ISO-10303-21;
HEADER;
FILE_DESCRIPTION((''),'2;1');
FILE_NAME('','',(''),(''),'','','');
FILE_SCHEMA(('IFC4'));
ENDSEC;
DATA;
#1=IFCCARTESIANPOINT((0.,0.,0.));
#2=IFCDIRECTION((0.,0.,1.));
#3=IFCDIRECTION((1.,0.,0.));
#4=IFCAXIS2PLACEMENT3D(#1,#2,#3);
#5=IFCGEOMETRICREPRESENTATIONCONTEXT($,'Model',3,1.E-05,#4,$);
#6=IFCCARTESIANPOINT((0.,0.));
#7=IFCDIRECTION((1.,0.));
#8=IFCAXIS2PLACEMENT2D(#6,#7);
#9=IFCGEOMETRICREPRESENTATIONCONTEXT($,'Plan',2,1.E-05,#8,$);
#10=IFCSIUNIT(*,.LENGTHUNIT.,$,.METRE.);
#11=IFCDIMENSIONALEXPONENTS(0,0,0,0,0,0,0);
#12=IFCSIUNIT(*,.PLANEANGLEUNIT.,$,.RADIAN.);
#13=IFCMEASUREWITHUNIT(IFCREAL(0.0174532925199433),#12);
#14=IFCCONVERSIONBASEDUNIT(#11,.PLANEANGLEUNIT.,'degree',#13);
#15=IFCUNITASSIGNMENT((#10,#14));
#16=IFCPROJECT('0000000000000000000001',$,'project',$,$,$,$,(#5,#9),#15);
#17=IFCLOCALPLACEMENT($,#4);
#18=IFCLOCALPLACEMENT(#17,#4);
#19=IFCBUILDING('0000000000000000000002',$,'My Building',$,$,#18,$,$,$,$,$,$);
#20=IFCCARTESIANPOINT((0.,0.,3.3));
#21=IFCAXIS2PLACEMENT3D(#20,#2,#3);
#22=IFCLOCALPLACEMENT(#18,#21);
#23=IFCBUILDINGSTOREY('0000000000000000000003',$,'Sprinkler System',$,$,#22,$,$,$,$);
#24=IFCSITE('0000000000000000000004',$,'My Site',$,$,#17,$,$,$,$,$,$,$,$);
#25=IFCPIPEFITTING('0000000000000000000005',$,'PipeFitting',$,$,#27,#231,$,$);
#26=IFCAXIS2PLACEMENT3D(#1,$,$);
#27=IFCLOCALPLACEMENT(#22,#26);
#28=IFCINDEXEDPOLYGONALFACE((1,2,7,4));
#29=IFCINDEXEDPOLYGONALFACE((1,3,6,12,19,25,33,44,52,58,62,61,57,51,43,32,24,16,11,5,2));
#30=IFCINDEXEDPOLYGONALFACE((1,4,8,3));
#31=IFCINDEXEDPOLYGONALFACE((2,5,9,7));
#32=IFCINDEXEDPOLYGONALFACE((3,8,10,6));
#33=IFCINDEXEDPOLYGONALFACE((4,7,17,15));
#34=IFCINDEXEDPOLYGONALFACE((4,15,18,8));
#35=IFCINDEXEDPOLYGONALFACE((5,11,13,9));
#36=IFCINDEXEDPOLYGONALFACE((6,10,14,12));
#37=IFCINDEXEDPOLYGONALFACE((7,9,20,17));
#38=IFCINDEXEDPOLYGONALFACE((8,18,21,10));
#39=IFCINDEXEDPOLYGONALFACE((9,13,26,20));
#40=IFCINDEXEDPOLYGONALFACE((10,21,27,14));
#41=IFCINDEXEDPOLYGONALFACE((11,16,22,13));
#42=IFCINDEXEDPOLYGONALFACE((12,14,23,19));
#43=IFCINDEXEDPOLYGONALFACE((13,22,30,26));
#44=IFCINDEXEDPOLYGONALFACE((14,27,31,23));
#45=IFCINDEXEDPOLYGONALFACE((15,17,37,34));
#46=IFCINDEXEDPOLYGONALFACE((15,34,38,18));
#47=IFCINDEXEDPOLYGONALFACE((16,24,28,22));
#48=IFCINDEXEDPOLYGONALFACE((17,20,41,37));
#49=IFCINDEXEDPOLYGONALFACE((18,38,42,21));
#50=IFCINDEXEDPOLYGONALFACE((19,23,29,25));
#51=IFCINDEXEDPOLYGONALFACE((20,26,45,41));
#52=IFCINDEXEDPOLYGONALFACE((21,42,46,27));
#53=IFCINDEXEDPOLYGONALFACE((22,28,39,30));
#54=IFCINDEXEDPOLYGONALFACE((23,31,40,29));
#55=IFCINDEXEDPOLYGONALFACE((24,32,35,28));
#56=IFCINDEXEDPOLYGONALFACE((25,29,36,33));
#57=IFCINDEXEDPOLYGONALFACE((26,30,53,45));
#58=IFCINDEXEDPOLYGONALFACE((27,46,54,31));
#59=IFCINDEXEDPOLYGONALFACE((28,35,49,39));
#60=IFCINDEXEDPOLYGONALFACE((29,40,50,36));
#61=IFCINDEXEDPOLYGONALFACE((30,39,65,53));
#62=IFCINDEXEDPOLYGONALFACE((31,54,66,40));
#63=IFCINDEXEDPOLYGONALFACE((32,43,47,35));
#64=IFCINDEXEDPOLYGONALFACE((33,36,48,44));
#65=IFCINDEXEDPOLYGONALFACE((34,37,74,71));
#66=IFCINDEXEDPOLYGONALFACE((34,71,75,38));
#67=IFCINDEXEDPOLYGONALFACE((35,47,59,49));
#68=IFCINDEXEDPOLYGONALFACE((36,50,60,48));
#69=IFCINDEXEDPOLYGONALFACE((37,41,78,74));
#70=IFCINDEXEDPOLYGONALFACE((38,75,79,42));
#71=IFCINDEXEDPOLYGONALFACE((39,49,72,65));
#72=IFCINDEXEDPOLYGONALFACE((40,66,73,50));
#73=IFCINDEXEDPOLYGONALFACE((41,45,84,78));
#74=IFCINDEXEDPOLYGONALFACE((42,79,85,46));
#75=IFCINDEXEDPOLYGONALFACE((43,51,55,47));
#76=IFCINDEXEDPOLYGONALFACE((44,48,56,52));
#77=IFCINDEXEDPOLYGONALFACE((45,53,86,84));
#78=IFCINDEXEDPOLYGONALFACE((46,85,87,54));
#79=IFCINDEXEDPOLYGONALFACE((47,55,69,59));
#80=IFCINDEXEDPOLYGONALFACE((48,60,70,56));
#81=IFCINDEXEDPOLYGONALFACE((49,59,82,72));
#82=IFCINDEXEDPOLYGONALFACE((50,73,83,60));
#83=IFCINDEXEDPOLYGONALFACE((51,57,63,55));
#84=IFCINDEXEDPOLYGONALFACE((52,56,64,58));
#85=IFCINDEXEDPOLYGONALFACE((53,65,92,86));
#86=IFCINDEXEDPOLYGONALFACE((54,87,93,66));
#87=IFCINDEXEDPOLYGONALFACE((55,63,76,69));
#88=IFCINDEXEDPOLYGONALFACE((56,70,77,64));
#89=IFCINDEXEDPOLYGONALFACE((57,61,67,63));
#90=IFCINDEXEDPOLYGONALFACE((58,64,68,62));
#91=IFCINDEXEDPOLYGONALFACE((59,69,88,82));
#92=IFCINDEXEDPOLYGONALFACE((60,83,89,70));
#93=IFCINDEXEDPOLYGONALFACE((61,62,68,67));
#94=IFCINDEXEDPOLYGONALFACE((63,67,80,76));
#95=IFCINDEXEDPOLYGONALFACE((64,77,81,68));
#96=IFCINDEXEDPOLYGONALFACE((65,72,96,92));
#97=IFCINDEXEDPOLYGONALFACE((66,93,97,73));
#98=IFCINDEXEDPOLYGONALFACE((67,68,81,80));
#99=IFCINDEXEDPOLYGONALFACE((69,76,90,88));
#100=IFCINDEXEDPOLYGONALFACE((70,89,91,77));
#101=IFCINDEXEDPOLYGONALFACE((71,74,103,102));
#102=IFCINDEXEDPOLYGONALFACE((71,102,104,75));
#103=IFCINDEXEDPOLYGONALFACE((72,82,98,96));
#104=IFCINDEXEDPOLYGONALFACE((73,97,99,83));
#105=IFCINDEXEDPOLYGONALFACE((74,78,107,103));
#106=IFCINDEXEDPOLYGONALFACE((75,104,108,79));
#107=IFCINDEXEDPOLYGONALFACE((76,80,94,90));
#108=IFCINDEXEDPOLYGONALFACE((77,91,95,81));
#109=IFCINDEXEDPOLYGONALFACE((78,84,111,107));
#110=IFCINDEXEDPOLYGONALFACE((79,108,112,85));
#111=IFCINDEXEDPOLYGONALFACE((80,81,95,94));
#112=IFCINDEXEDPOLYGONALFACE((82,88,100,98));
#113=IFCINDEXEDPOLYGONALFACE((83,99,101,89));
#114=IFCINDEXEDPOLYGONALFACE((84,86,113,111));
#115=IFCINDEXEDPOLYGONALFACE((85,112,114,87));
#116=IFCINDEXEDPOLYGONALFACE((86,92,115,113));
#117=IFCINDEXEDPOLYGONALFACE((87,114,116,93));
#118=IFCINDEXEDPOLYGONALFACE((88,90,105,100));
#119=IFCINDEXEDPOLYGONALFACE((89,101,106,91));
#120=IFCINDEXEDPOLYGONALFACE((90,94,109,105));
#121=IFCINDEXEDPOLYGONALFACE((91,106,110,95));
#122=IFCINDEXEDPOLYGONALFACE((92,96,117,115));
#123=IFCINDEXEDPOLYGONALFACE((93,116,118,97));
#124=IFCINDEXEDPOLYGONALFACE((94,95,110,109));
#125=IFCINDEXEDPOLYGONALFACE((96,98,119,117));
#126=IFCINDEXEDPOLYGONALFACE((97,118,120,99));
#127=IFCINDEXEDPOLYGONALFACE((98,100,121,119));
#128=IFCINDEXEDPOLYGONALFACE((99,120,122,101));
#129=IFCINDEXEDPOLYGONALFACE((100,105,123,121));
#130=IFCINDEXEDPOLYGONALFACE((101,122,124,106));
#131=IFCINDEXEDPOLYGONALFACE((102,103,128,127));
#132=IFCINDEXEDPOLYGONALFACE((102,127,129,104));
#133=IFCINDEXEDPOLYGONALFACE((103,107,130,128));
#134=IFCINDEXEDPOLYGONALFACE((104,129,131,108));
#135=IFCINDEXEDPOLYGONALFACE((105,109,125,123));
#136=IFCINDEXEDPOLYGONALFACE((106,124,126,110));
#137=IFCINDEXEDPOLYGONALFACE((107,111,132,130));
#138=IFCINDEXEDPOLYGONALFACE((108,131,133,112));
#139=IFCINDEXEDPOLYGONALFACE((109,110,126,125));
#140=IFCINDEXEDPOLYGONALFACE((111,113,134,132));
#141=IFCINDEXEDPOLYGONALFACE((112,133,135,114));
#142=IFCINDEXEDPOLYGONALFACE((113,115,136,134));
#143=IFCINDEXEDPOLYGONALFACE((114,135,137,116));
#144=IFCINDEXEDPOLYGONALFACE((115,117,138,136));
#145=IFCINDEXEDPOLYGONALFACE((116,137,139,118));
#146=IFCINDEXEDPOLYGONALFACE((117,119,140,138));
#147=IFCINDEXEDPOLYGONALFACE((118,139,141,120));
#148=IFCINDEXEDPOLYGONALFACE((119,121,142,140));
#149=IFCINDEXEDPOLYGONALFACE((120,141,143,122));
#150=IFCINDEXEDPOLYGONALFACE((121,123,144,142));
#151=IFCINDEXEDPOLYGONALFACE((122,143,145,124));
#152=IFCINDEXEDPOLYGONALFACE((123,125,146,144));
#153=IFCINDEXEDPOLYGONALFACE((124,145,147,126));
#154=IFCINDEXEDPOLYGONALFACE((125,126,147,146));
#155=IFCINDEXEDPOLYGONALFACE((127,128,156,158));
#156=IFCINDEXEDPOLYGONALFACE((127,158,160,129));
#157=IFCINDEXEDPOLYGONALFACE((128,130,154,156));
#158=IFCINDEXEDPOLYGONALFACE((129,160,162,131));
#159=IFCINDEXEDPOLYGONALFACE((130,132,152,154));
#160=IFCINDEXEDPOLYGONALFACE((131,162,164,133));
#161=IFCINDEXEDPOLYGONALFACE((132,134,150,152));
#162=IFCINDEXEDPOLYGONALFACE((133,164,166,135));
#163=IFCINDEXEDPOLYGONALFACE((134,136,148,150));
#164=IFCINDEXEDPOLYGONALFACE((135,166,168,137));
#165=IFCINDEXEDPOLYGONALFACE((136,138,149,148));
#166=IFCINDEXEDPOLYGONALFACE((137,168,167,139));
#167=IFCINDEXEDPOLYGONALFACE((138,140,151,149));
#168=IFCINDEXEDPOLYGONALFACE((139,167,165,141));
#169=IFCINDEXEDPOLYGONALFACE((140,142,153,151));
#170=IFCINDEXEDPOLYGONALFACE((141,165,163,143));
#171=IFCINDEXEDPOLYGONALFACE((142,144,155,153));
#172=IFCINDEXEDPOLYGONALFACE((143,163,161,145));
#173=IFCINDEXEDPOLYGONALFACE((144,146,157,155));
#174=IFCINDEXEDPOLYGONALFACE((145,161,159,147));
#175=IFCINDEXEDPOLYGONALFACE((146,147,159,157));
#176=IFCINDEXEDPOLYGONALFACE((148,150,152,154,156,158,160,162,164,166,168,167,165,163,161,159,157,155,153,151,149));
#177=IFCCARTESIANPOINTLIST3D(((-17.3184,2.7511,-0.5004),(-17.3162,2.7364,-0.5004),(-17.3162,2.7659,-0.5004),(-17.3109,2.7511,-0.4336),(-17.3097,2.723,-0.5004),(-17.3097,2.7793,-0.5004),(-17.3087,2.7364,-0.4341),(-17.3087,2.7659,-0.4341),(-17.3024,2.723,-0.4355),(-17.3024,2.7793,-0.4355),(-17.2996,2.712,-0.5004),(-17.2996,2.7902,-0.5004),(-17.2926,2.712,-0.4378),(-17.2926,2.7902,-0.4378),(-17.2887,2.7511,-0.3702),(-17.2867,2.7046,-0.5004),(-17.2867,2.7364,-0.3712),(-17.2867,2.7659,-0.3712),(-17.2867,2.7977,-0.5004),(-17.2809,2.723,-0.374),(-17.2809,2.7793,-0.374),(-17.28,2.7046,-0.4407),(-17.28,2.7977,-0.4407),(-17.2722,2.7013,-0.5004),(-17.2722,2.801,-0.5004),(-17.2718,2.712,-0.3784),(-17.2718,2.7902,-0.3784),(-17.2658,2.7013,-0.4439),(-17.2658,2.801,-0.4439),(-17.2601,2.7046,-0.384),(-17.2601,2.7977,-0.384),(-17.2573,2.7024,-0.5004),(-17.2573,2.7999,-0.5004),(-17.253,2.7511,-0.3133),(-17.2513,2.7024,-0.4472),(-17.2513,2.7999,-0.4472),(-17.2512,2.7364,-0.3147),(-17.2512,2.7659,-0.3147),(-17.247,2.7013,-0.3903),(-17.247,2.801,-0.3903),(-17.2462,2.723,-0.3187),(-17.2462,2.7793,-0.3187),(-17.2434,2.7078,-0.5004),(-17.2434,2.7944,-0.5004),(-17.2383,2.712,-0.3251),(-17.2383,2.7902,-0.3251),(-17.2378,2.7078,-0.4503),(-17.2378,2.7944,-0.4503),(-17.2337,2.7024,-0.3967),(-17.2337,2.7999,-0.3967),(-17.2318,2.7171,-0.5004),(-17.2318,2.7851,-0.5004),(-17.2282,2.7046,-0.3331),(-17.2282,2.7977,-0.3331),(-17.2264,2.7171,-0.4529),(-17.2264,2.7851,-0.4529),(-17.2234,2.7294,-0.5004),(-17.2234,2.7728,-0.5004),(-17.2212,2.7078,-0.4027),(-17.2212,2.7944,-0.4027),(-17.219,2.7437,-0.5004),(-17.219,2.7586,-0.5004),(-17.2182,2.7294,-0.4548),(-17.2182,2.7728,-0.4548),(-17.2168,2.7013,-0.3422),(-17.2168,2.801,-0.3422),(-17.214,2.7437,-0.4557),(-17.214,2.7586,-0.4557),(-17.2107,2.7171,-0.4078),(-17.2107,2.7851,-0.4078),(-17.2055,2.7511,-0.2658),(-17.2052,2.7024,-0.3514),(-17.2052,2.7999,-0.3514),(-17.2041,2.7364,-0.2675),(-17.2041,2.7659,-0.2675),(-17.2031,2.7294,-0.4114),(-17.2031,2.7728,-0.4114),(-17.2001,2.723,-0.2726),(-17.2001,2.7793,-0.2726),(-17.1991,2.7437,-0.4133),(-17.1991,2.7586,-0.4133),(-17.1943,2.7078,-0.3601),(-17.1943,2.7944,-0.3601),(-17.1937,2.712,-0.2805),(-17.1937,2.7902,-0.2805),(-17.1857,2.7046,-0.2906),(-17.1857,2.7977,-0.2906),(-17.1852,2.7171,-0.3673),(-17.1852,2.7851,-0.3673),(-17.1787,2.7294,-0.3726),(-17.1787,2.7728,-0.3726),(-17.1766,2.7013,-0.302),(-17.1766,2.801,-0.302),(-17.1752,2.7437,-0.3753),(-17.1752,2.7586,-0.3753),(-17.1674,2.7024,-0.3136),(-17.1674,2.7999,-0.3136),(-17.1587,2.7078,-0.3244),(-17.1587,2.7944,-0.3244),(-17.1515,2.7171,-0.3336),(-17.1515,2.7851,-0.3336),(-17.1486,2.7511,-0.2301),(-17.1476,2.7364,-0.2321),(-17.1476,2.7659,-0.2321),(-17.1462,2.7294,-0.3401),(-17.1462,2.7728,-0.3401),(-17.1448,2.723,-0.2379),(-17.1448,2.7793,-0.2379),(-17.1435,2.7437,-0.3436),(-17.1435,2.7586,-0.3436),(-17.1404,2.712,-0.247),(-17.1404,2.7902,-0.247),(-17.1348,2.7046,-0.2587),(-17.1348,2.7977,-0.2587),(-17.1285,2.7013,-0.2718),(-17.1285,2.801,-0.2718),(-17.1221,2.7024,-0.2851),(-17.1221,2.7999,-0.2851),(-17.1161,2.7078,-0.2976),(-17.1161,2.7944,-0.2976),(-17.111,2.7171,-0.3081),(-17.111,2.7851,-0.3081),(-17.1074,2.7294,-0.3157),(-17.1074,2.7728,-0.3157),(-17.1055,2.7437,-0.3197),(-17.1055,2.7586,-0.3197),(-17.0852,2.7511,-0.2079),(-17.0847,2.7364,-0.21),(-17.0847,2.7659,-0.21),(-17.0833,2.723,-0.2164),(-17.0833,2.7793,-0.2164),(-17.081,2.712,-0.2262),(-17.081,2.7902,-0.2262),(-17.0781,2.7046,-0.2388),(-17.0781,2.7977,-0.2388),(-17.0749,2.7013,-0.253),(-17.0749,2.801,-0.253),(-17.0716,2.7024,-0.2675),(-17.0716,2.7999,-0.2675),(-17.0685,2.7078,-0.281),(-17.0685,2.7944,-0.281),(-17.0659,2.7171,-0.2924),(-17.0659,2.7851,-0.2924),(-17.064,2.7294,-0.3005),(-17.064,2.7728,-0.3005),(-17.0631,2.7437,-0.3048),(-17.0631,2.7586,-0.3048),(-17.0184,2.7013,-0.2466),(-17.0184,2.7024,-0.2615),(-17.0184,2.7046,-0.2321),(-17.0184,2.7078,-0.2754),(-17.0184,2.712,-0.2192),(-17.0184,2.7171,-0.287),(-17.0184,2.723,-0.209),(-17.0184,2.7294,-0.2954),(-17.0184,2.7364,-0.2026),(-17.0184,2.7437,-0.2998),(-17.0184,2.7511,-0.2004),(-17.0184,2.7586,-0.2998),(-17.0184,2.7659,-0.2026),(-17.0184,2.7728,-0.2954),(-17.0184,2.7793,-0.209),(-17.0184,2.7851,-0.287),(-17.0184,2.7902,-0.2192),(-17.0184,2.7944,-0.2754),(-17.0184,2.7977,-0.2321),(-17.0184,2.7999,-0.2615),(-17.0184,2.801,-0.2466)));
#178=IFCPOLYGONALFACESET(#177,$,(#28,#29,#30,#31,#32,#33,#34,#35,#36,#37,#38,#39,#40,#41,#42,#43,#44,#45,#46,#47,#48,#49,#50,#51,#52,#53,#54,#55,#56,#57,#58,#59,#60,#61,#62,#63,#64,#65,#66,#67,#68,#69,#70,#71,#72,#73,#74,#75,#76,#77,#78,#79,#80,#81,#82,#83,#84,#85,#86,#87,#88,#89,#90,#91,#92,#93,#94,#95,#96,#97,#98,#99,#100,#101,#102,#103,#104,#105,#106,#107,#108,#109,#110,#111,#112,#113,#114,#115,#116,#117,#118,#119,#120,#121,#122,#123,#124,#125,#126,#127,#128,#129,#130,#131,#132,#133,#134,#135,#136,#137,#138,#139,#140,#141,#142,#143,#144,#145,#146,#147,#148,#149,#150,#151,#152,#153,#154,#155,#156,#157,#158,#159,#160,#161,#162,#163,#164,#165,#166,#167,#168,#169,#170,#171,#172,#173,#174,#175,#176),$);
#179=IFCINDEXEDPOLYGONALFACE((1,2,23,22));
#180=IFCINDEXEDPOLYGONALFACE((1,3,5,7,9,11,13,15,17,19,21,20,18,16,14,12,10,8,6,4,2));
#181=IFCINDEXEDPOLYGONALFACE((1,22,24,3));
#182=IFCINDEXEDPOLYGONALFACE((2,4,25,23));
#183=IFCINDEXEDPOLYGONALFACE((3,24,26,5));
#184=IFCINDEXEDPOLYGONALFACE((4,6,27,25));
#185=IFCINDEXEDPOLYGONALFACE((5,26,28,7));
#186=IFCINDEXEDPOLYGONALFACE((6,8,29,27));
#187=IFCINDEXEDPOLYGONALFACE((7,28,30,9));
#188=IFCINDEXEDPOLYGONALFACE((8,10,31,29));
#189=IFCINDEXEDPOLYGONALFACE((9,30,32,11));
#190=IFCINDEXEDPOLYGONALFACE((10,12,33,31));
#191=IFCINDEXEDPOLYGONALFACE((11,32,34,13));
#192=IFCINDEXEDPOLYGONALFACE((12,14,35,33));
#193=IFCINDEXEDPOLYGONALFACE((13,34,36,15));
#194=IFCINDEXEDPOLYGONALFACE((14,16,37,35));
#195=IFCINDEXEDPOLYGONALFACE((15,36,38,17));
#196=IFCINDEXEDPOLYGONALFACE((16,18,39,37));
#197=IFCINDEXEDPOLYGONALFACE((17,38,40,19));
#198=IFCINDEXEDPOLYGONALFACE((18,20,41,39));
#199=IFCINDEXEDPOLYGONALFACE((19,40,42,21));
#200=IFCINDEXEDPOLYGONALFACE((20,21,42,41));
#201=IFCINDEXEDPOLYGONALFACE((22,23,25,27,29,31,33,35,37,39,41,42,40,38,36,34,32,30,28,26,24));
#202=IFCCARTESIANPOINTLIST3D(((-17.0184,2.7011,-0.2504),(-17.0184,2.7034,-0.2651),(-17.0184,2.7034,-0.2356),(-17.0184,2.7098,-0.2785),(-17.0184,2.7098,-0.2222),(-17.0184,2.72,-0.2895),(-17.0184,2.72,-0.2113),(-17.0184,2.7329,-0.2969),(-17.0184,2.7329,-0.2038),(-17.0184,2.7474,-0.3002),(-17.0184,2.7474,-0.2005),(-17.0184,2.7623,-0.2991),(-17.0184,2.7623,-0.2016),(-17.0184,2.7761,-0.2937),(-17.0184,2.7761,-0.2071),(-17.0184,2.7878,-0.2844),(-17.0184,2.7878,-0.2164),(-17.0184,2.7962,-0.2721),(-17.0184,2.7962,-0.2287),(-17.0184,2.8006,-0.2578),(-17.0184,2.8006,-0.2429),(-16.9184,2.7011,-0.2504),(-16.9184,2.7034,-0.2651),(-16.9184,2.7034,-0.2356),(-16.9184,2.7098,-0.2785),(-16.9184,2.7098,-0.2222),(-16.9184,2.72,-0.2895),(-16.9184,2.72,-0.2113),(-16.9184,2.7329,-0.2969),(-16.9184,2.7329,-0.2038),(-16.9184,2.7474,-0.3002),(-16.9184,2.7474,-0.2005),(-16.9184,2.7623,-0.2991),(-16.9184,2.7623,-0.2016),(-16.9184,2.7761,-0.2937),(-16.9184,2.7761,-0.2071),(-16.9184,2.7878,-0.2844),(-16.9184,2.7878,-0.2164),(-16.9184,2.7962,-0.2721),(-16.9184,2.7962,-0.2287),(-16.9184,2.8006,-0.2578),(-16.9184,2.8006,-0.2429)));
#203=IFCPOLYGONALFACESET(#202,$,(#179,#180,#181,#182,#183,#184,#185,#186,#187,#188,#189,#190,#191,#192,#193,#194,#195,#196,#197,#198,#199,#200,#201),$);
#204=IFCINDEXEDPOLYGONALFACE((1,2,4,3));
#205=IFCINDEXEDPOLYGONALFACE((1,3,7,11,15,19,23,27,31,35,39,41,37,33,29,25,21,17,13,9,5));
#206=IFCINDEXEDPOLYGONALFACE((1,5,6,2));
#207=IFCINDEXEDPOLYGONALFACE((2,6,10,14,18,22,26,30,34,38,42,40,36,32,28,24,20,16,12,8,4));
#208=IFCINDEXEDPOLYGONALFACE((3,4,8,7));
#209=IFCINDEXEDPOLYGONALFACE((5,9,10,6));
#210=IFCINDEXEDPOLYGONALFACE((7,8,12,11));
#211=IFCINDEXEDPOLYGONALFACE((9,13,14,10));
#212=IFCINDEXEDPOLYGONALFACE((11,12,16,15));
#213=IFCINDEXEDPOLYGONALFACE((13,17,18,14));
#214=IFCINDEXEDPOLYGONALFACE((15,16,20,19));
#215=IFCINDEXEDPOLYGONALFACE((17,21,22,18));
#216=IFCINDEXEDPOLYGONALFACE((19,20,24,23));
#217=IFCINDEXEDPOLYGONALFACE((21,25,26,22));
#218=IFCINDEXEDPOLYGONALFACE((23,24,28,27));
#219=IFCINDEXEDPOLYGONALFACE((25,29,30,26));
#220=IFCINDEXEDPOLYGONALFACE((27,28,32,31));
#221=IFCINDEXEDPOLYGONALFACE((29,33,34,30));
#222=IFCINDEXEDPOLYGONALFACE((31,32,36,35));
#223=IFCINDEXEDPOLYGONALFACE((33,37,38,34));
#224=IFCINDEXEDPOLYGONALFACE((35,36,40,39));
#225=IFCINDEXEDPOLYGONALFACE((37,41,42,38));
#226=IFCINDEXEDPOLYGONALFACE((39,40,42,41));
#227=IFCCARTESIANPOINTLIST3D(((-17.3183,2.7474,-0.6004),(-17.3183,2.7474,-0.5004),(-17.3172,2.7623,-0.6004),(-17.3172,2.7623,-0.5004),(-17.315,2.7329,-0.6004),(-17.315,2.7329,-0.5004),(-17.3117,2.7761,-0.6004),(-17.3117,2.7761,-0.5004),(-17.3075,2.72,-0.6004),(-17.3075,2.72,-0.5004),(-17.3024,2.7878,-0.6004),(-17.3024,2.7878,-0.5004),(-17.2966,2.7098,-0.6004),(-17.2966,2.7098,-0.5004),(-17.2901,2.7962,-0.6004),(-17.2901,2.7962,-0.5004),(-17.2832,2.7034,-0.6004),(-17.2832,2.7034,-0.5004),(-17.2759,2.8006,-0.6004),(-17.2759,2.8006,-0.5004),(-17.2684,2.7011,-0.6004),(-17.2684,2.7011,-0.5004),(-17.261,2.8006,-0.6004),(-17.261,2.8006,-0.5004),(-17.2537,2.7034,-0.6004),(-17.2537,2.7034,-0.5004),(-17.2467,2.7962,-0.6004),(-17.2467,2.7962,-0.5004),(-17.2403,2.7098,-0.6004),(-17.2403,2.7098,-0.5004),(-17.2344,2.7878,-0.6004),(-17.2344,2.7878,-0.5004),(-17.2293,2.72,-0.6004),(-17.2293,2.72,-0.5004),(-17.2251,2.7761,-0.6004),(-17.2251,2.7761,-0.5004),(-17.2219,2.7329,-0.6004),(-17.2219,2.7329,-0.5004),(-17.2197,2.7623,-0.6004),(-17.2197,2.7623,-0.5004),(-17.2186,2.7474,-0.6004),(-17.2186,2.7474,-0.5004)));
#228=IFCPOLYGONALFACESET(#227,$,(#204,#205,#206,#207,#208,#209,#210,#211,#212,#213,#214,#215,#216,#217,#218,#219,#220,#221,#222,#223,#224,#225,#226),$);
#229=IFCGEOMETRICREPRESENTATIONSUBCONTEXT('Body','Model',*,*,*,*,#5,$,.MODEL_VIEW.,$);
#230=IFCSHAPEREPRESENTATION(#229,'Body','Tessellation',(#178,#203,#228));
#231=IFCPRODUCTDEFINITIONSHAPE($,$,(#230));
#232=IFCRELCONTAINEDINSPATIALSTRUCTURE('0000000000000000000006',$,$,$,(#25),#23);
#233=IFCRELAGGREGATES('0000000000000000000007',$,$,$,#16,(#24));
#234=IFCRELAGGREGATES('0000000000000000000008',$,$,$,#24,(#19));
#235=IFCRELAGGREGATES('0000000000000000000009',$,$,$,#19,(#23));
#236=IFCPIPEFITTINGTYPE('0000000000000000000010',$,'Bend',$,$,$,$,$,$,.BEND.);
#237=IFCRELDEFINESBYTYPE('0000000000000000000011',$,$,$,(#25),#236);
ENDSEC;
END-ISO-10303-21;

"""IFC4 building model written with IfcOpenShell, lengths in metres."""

from ifc_helpers import new_model, entity, si_unit, converted_unit, frame, origin_with_axes, origin_2d_with_axis, place, context, subcontext, project, spatial, circle, extrude, source, transform, mapped, type_object, type_shapes, element, save


model = new_model("IFC4")

# Units and contexts
model_context = context("Model", 3, precision=1e-05, world=origin_with_axes())
plan_context = context("Plan", 2, precision=1e-05, world=origin_2d_with_axis())
body_context = subcontext(model_context, "Body", "Model", "MODEL_VIEW")
ifc_project = project(units=[si_unit("LENGTHUNIT", "METRE"), converted_unit("PLANEANGLEUNIT", "degree", entity("IfcReal", 0.0174532925199433), si_unit("PLANEANGLEUNIT", "RADIAN"), dimensions=[0, 0, 0, 0, 0, 0, 0])], contexts=[model_context, plan_context])

# Site, building, storey
site_placement = place(None, origin_with_axes())
site = spatial("IfcSite", under=ifc_project, at=site_placement, Name="My Site")
building_placement = place(site_placement, origin_with_axes())
building = spatial("IfcBuilding", under=site, at=building_placement, Name="My Building")
storey_placement = place(building_placement, frame((0.0, 0.0, 3.3), z_axis=(0.0, 0.0, 1.0), x_axis=(1.0, 0.0, 0.0)))
storey = spatial("IfcBuildingStorey", under=building, at=storey_placement, Name="Sprinkler System")

# Pipe fitting
pipe_fitting_type_1 = type_object("IfcPipeFittingType", Name="Bend", PredefinedType="BEND")
shared_shape_1 = source(origin_with_axes(), body_context, "Body", "SolidModel", [
    entity("IfcSweptDiskSolid", entity("IfcIndexedPolyCurve", entity("IfcCartesianPointList3D", [[0.0, 0.0, -0.1], [0.0, 0.0732, -0.2768], [0.0, 0.25, -0.35]]), [entity("IfcArcIndex", [1, 2, 3])]), 0.05),
    extrude(circle(Radius=0.05), origin_with_axes(), (0.0, 0.0, -1.0), 0.1),
    extrude(circle(Radius=0.05), frame((0.0, 0.25, -0.35), z_axis=(0.0, 1.0, 0.0), x_axis=(1.0, 0.0, 0.0)), (0.0, 0.0, 1.0), 0.1),
])
type_shapes(pipe_fitting_type_1, [shared_shape_1])
for number, where, z_axis, x_axis, name in (
    (1, (-16.9184, 2.7511, -0.2504), (1.0, 0.0, 0.0), (0.0, -1.0, 0.0), "PipeFitting"),
):
    element("IfcPipeFitting", number, at=place(storey_placement, frame(where, z_axis=z_axis, x_axis=x_axis)), inside=storey, type_object=pipe_fitting_type_1, Name=name, context=body_context, shape_type="MappedRepresentation", body=[
        mapped(shared_shape_1, transform((0.0, 0.0, 0.0), x_axis=(1.0, 0.0, 0.0), y_axis=(0.0, 1.0, 0.0), z_axis=(0.0, 0.0, 1.0), scale=1.0)),
    ])

save(model, "model.ifc")
